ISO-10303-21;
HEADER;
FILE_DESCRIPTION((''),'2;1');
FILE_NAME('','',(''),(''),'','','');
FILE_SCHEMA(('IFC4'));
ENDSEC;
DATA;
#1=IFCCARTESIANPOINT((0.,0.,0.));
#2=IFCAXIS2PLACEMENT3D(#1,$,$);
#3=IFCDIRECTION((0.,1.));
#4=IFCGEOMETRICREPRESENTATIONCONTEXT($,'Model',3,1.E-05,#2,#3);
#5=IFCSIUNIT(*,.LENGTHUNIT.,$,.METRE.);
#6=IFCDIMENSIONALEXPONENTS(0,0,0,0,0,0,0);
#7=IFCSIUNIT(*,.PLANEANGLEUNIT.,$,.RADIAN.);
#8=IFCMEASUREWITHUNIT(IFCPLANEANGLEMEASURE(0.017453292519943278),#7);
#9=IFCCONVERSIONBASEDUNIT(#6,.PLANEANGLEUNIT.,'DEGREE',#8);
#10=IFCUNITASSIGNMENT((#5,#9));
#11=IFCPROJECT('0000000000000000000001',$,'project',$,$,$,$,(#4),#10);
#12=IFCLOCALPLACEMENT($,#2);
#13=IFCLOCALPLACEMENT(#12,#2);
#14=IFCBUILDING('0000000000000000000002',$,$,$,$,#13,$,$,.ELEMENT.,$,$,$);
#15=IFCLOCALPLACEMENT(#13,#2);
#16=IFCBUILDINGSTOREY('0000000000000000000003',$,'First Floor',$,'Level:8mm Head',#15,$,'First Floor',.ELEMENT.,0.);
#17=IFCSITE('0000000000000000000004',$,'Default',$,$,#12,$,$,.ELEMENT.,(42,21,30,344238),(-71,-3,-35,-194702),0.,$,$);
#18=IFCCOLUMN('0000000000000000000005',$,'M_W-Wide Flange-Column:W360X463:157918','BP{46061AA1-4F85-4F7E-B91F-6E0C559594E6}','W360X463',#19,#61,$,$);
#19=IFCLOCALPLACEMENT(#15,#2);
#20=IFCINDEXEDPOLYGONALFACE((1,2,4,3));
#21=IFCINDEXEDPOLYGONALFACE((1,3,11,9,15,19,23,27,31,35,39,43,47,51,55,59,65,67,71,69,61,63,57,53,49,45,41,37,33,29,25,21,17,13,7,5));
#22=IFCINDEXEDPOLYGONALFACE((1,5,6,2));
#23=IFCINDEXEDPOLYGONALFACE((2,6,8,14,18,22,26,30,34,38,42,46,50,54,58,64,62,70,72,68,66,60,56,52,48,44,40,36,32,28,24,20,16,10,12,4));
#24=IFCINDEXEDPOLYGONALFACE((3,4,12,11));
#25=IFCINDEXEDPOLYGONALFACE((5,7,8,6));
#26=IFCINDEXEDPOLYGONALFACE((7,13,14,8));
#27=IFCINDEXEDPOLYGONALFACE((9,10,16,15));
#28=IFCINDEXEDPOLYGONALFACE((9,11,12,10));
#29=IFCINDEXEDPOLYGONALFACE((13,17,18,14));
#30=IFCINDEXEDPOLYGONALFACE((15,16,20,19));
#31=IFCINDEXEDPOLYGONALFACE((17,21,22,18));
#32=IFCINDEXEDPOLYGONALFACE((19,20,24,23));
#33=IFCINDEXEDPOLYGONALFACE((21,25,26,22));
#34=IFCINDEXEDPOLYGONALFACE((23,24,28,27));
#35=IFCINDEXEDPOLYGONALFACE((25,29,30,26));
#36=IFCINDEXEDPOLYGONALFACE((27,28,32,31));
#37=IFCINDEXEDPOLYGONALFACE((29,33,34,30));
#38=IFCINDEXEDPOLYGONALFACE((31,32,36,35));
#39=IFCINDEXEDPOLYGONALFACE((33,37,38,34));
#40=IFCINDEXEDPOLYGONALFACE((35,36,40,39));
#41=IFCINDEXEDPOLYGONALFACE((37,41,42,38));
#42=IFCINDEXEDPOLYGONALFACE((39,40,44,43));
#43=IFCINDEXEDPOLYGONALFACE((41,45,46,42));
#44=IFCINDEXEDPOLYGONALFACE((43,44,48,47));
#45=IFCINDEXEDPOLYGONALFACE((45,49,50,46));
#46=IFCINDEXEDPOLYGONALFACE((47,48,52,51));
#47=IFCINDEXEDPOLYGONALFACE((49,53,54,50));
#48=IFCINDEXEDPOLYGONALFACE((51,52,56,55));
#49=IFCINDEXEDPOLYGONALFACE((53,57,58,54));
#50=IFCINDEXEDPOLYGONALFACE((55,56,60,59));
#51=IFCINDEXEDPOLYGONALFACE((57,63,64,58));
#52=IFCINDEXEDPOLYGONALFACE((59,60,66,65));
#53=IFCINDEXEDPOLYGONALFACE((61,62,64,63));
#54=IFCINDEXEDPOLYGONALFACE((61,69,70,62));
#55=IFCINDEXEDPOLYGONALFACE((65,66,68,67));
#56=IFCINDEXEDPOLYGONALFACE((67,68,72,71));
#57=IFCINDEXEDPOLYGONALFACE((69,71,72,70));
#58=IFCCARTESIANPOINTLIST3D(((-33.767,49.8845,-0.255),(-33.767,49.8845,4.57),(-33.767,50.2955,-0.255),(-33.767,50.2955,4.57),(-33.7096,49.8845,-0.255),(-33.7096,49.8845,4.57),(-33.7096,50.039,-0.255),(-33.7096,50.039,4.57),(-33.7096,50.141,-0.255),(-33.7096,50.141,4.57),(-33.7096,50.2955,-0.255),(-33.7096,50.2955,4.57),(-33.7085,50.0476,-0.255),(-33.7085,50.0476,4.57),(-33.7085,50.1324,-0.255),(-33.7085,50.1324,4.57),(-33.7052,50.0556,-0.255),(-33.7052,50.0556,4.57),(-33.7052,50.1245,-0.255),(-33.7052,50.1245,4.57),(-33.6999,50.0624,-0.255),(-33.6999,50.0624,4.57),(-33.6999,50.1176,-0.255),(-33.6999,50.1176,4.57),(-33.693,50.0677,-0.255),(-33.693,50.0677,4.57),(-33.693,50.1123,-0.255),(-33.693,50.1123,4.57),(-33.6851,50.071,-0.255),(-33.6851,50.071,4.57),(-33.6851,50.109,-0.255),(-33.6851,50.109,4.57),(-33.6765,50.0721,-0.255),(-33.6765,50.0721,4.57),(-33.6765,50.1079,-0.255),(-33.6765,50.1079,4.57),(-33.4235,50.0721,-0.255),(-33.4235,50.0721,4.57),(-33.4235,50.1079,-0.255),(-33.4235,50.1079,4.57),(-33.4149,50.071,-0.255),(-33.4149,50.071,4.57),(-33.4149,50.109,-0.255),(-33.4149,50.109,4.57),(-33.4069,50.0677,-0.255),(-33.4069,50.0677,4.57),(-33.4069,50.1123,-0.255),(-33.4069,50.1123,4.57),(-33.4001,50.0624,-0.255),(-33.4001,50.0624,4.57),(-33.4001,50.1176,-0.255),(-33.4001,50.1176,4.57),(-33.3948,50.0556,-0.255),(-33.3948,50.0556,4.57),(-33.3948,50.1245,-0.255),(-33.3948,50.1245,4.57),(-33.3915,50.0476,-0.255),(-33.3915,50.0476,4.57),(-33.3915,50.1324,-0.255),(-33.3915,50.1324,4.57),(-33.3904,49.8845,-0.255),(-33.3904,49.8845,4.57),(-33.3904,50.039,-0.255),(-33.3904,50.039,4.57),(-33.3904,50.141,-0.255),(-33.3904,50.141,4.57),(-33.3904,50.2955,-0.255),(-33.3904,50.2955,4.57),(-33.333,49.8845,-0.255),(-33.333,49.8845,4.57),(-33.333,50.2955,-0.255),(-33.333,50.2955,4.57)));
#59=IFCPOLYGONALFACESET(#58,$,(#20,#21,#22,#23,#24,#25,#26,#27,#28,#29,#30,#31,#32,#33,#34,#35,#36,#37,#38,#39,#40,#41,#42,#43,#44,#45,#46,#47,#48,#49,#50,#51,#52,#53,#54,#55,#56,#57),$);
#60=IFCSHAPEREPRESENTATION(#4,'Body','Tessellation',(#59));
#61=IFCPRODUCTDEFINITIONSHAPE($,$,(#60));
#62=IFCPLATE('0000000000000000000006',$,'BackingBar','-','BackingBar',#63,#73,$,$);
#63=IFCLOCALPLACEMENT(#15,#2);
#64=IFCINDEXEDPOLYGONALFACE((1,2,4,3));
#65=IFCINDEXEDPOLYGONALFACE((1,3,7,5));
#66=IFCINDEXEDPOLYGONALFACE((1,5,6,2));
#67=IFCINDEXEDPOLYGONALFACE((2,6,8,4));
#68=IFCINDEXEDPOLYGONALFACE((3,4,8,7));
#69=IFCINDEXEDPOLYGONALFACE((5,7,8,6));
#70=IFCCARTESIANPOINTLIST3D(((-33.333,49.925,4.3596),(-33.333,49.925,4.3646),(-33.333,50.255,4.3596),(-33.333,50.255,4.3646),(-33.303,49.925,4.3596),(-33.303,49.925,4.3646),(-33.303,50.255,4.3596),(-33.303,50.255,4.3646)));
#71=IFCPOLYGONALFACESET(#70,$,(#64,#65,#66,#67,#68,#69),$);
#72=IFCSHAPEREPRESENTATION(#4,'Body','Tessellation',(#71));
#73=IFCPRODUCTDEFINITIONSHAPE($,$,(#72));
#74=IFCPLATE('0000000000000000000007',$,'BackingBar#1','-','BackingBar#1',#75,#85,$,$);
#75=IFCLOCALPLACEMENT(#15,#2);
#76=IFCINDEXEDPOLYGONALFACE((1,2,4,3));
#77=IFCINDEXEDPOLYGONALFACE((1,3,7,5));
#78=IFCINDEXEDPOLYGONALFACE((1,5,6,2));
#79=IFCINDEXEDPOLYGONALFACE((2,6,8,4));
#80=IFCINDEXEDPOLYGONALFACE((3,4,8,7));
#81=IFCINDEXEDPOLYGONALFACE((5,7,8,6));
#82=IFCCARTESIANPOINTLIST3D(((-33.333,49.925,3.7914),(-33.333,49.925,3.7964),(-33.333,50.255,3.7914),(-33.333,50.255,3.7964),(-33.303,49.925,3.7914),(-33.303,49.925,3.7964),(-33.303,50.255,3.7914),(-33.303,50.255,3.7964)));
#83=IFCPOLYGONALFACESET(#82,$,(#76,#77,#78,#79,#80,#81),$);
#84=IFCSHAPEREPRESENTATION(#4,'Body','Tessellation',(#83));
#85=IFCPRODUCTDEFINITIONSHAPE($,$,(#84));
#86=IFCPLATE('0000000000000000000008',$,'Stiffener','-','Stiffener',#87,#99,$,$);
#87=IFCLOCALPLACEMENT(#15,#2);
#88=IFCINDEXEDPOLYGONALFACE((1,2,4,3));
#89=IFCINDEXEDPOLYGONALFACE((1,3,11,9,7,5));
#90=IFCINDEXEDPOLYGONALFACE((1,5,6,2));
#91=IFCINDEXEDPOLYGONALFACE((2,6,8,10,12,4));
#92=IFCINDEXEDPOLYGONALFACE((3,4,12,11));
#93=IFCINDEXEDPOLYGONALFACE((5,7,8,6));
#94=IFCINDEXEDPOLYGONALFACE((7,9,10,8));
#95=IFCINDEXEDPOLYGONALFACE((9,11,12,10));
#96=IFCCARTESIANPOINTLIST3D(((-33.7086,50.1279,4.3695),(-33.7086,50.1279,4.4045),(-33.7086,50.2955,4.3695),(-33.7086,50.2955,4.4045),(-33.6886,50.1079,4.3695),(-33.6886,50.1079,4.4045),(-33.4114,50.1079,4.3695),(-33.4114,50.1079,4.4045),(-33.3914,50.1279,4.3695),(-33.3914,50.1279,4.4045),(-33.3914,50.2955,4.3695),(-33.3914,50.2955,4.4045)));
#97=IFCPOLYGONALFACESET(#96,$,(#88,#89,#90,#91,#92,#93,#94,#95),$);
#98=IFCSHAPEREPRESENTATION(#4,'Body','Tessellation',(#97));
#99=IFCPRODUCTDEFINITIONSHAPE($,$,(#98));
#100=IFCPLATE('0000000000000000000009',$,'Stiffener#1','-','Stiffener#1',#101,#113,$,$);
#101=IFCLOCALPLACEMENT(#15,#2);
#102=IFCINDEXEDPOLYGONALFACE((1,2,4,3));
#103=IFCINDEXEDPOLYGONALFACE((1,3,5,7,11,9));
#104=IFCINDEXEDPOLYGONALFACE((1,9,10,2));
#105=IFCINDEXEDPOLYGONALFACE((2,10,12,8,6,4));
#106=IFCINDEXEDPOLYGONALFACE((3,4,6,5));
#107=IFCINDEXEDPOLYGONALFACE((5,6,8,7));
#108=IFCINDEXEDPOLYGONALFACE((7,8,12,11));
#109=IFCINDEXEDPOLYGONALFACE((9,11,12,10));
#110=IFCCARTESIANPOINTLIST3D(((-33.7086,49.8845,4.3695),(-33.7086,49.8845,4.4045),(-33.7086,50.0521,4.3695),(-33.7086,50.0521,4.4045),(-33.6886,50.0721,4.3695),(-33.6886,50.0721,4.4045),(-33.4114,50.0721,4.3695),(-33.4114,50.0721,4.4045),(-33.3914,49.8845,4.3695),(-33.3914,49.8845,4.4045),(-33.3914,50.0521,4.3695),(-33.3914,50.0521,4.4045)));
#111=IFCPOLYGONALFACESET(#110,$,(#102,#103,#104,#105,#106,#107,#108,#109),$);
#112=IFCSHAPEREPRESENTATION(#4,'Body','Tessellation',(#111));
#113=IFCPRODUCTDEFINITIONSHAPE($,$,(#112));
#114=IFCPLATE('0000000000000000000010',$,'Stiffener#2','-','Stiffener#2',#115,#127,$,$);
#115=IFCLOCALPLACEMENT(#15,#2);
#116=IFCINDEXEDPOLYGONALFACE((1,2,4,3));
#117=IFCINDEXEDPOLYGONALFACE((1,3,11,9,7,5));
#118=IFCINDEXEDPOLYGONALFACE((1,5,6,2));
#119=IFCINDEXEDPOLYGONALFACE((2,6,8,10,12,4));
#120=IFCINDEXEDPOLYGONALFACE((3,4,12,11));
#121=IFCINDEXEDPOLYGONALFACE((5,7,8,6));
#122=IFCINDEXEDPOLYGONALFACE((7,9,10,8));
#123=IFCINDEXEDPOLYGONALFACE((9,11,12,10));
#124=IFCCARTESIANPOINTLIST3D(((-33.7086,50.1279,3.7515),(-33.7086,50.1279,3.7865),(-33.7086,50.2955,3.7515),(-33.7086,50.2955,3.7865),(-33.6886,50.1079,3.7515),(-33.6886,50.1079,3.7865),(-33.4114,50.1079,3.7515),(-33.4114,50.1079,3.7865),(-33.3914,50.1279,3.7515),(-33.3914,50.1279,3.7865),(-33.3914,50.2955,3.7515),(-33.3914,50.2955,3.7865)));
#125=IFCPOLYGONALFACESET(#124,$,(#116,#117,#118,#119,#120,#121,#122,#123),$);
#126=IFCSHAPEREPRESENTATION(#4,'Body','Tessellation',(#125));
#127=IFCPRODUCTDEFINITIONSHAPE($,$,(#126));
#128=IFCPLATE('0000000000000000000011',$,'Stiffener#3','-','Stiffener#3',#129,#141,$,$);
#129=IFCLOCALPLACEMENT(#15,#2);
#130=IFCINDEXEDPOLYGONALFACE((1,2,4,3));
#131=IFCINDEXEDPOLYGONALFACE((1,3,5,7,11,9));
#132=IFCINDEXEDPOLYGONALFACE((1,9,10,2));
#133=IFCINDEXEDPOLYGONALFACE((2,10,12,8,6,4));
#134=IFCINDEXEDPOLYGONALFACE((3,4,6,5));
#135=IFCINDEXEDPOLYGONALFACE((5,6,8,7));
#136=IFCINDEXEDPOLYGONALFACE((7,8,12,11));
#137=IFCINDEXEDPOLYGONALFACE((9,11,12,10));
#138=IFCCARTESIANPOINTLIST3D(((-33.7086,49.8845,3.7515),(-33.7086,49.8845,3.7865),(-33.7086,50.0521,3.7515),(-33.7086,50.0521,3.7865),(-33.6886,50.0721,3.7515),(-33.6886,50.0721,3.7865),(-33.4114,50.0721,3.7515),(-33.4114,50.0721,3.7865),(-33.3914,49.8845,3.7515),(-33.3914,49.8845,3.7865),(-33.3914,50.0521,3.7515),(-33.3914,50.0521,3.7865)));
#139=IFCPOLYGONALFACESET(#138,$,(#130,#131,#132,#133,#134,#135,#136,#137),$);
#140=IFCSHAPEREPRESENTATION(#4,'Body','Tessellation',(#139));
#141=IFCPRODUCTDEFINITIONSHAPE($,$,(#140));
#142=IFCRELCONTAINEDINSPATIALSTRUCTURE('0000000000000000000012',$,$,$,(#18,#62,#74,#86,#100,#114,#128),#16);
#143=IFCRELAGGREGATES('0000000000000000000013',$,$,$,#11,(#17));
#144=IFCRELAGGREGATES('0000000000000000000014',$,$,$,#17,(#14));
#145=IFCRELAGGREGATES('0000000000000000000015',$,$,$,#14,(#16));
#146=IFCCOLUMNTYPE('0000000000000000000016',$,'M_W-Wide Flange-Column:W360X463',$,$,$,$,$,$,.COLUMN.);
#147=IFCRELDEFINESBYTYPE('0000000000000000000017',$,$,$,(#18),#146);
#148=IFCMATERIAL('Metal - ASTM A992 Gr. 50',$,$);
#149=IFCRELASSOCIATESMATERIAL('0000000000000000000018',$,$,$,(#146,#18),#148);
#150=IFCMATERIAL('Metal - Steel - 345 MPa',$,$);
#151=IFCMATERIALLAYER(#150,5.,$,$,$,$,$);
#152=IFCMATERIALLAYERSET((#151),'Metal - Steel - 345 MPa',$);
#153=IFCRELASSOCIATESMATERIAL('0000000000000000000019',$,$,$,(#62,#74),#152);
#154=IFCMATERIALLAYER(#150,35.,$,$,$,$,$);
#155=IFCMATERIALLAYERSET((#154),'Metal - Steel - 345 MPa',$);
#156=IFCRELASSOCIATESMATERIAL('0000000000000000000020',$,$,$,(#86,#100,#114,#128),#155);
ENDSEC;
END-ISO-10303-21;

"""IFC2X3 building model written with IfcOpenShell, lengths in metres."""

from ifc_helpers import new_model, entity, si_unit, converted_unit, direction, frame, origin, origin_with_axes, origin_2d, place, context, project, spatial, polyline, i_section, outline, extrude, clip, halfspace, material, layer, layer_set, type_object, element, save


model = new_model("IFC2X3")

# Units and contexts
model_context = context("Model", 3, precision=1e-05, world=origin(), true_north=direction((0.0, 1.0)))
ifc_project = project(units=[si_unit("LENGTHUNIT", "METRE"), converted_unit("PLANEANGLEUNIT", "DEGREE", entity("IfcPlaneAngleMeasure", 0.017453292519943278), si_unit("PLANEANGLEUNIT", "RADIAN"), dimensions=[0, 0, 0, 0, 0, 0, 0])], contexts=[model_context])

# Site, building, storey
site_placement = place(None, origin())
site = spatial("IfcSite", under=ifc_project, at=site_placement, Name="Default", CompositionType="ELEMENT", RefLatitude=(42, 21, 30, 344238), RefLongitude=(-71, -3, -35, -194702), RefElevation=0.0)
building_placement = place(site_placement, origin())
building = spatial("IfcBuilding", under=site, at=building_placement, CompositionType="ELEMENT")
storey_placement = place(building_placement, origin())
storey = spatial("IfcBuildingStorey", under=building, at=storey_placement, Name="First Floor", ObjectType="Level:8mm Head", LongName="First Floor", CompositionType="ELEMENT", Elevation=0.0)

# Column
ifc_material_1 = material(Name="Metal - ASTM A992 Gr. 50")
column_type_1 = type_object("IfcColumnType", Name="M_W-Wide Flange-Column:W360X463", PredefinedType="COLUMN", material=ifc_material_1)
column_1_placement = place(storey_placement, frame((-33.55, 50.09, 4.57), z_axis=(0.0, 0.0, 1.0), x_axis=(0.0, 1.0, 0.0)))
element("IfcColumn", 1, at=column_1_placement, inside=storey, type_object=column_type_1, material=ifc_material_1, Name="M_W-Wide Flange-Column:W360X463:157918", Description="BP{46061AA1-4F85-4F7E-B91F-6E0C559594E6}", ObjectType="W360X463", context=model_context, shape_type="Clipping", body=[
    clip(extrude(i_section(OverallWidth=0.411, OverallDepth=0.434, WebThickness=0.0358, FlangeThickness=0.0574, FilletRadius=0.0331, at=origin_2d()), origin(), (0.0, 0.0, -1.0), 5.1739), halfspace(frame((-50.09, -33.55, -4.825), z_axis=(0.0, 0.0, 1.0), x_axis=(0.0, -1.0, 0.0)), True)),
])

# Plates
ifc_material_2 = material(Name="Metal - Steel - 345 MPa")
ifc_layer_1 = layer(ifc_material_2, 5.0)
ifc_layer_set_1 = layer_set([ifc_layer_1], Name="Metal - Steel - 345 MPa")
plate_1_placement = place(storey_placement, frame((-33.333, 50.255, 4.3596), z_axis=(0.0, 0.0, 1.0), x_axis=(0.0, -1.0, 0.0)))
element("IfcPlate", 2, at=plate_1_placement, inside=storey, material=ifc_layer_set_1, Name="BackingBar", Description="-", ObjectType="BackingBar", context=model_context, shape_type="SweptSolid", body=[
    extrude(outline(polyline([(0.0, 0.0), (0.33, 0.0), (0.33, 0.03), (0.0, 0.03), (0.0, 0.0)])), origin_with_axes(), (0.0, 0.0, 1.0), 0.005),
])
plate_2_placement = place(storey_placement, frame((-33.333, 49.925, 3.7964), z_axis=(0.0, 0.0, -1.0), x_axis=(0.0, 1.0, 0.0)))
element("IfcPlate", 3, at=plate_2_placement, inside=storey, material=ifc_layer_set_1, Name="BackingBar#1", Description="-", ObjectType="BackingBar#1", context=model_context, shape_type="SweptSolid", body=[
    extrude(outline(polyline([(0.0, 0.0), (0.33, 0.0), (0.33, 0.03), (0.0, 0.03), (0.0, 0.0)])), origin_with_axes(), (0.0, 0.0, 1.0), 0.005),
])

# Plates, openings
ifc_layer_2 = layer(ifc_material_2, 35.0)
ifc_layer_set_2 = layer_set([ifc_layer_2], Name="Metal - Steel - 345 MPa")
plate_3_placement = place(storey_placement, frame((-33.3914, 50.1079, 4.3695), z_axis=(0.0, 0.0, 1.0), x_axis=(0.0, 1.0, 0.0)))
plate_3 = element("IfcPlate", 4, at=plate_3_placement, inside=storey, material=ifc_layer_set_2, Name="Stiffener", Description="-", ObjectType="Stiffener", context=model_context, shape_type="SweptSolid", body=[
    extrude(outline(polyline([(0.0, 0.0), (0.1876, 0.0), (0.1876, 0.3172), (0.0, 0.3172), (0.0, 0.0)])), origin_with_axes(), (0.0, 0.0, 1.0), 0.035),
])
opening_1_placement = place(plate_3_placement, frame((0.0, 0.0, 0.0), z_axis=(0.0, 0.0, 1.0), x_axis=(1.0, 0.0, 0.0)))
element("IfcOpeningElement", 5, at=opening_1_placement, cuts=plate_3, ObjectType="Opening", context=model_context, shape_type="SweptSolid", body=[
    extrude(outline(polyline([(0.0, 0.3172), (0.0, 0.2972), (0.02, 0.3172), (0.0, 0.3172)])), origin(), (0.0, 0.0, 1.0), 0.035),
])
opening_2_placement = place(plate_3_placement, frame((0.0, 0.0, 0.0), z_axis=(0.0, 0.0, 1.0), x_axis=(1.0, 0.0, 0.0)))
element("IfcOpeningElement", 6, at=opening_2_placement, cuts=plate_3, ObjectType="Opening", context=model_context, shape_type="SweptSolid", body=[
    extrude(outline(polyline([(0.0, 0.0), (0.02, 0.0), (0.0, 0.02), (0.0, 0.0)])), origin(), (0.0, 0.0, 1.0), 0.035),
])
plate_4_placement = place(storey_placement, frame((-33.3914, 49.8845, 4.3695), z_axis=(0.0, 0.0, 1.0), x_axis=(0.0, 1.0, 0.0)))
plate_4 = element("IfcPlate", 7, at=plate_4_placement, inside=storey, material=ifc_layer_set_2, Name="Stiffener#1", Description="-", ObjectType="Stiffener#1", context=model_context, shape_type="SweptSolid", body=[
    extrude(outline(polyline([(0.0, 0.0), (0.1876, 0.0), (0.1876, 0.3172), (0.0, 0.3172), (0.0, 0.0)])), origin_with_axes(), (0.0, 0.0, 1.0), 0.035),
])
opening_3_placement = place(plate_4_placement, frame((0.0, 0.0, 0.0), z_axis=(0.0, 0.0, 1.0), x_axis=(1.0, 0.0, 0.0)))
element("IfcOpeningElement", 8, at=opening_3_placement, cuts=plate_4, ObjectType="Opening", context=model_context, shape_type="SweptSolid", body=[
    extrude(outline(polyline([(0.1876, 0.3172), (0.1676, 0.3172), (0.1876, 0.2972), (0.1876, 0.3172)])), origin(), (0.0, 0.0, 1.0), 0.035),
])
opening_4_placement = place(plate_4_placement, frame((0.0, 0.0, 0.0), z_axis=(0.0, 0.0, 1.0), x_axis=(1.0, 0.0, 0.0)))
element("IfcOpeningElement", 9, at=opening_4_placement, cuts=plate_4, ObjectType="Opening", context=model_context, shape_type="SweptSolid", body=[
    extrude(outline(polyline([(0.1876, 0.0), (0.1876, 0.02), (0.1676, 0.0), (0.1876, 0.0)])), origin(), (0.0, 0.0, 1.0), 0.035),
])
plate_5_placement = place(storey_placement, frame((-33.3914, 50.2955, 3.7865), z_axis=(0.0, 0.0, -1.0), x_axis=(0.0, -1.0, 0.0)))
plate_5 = element("IfcPlate", 10, at=plate_5_placement, inside=storey, material=ifc_layer_set_2, Name="Stiffener#2", Description="-", ObjectType="Stiffener#2", context=model_context, shape_type="SweptSolid", body=[
    extrude(outline(polyline([(0.0, 0.0), (0.1876, 0.0), (0.1876, 0.3172), (0.0, 0.3172), (0.0, 0.0)])), origin_with_axes(), (0.0, 0.0, 1.0), 0.035),
])
opening_5_placement = place(plate_5_placement, frame((0.0, 0.0, 0.0), z_axis=(0.0, 0.0, 1.0), x_axis=(1.0, 0.0, 0.0)))
element("IfcOpeningElement", 11, at=opening_5_placement, cuts=plate_5, ObjectType="Opening", context=model_context, shape_type="SweptSolid", body=[
    extrude(outline(polyline([(0.1876, 0.3172), (0.1676, 0.3172), (0.1876, 0.2972), (0.1876, 0.3172)])), origin(), (0.0, 0.0, 1.0), 0.035),
])
opening_6_placement = place(plate_5_placement, frame((0.0, 0.0, 0.0), z_axis=(0.0, 0.0, 1.0), x_axis=(1.0, 0.0, 0.0)))
element("IfcOpeningElement", 12, at=opening_6_placement, cuts=plate_5, ObjectType="Opening", context=model_context, shape_type="SweptSolid", body=[
    extrude(outline(polyline([(0.1876, 0.0), (0.1876, 0.02), (0.1676, 0.0), (0.1876, 0.0)])), origin(), (0.0, 0.0, 1.0), 0.035),
])
plate_6_placement = place(storey_placement, frame((-33.3914, 50.0721, 3.7865), z_axis=(0.0, 0.0, -1.0), x_axis=(0.0, -1.0, 0.0)))
plate_6 = element("IfcPlate", 13, at=plate_6_placement, inside=storey, material=ifc_layer_set_2, Name="Stiffener#3", Description="-", ObjectType="Stiffener#3", context=model_context, shape_type="SweptSolid", body=[
    extrude(outline(polyline([(0.0, 0.0), (0.1876, 0.0), (0.1876, 0.3172), (0.0, 0.3172), (0.0, 0.0)])), origin_with_axes(), (0.0, 0.0, 1.0), 0.035),
])
opening_7_placement = place(plate_6_placement, frame((0.0, 0.0, 0.0), z_axis=(0.0, 0.0, 1.0), x_axis=(1.0, 0.0, 0.0)))
element("IfcOpeningElement", 14, at=opening_7_placement, cuts=plate_6, ObjectType="Opening", context=model_context, shape_type="SweptSolid", body=[
    extrude(outline(polyline([(0.0, 0.3172), (0.0, 0.2972), (0.02, 0.3172), (0.0, 0.3172)])), origin(), (0.0, 0.0, 1.0), 0.035),
])
opening_8_placement = place(plate_6_placement, frame((0.0, 0.0, 0.0), z_axis=(0.0, 0.0, 1.0), x_axis=(1.0, 0.0, 0.0)))
element("IfcOpeningElement", 15, at=opening_8_placement, cuts=plate_6, ObjectType="Opening", context=model_context, shape_type="SweptSolid", body=[
    extrude(outline(polyline([(0.0, 0.0), (0.02, 0.0), (0.0, 0.02), (0.0, 0.0)])), origin(), (0.0, 0.0, 1.0), 0.035),
])

save(model, "model.ifc")
